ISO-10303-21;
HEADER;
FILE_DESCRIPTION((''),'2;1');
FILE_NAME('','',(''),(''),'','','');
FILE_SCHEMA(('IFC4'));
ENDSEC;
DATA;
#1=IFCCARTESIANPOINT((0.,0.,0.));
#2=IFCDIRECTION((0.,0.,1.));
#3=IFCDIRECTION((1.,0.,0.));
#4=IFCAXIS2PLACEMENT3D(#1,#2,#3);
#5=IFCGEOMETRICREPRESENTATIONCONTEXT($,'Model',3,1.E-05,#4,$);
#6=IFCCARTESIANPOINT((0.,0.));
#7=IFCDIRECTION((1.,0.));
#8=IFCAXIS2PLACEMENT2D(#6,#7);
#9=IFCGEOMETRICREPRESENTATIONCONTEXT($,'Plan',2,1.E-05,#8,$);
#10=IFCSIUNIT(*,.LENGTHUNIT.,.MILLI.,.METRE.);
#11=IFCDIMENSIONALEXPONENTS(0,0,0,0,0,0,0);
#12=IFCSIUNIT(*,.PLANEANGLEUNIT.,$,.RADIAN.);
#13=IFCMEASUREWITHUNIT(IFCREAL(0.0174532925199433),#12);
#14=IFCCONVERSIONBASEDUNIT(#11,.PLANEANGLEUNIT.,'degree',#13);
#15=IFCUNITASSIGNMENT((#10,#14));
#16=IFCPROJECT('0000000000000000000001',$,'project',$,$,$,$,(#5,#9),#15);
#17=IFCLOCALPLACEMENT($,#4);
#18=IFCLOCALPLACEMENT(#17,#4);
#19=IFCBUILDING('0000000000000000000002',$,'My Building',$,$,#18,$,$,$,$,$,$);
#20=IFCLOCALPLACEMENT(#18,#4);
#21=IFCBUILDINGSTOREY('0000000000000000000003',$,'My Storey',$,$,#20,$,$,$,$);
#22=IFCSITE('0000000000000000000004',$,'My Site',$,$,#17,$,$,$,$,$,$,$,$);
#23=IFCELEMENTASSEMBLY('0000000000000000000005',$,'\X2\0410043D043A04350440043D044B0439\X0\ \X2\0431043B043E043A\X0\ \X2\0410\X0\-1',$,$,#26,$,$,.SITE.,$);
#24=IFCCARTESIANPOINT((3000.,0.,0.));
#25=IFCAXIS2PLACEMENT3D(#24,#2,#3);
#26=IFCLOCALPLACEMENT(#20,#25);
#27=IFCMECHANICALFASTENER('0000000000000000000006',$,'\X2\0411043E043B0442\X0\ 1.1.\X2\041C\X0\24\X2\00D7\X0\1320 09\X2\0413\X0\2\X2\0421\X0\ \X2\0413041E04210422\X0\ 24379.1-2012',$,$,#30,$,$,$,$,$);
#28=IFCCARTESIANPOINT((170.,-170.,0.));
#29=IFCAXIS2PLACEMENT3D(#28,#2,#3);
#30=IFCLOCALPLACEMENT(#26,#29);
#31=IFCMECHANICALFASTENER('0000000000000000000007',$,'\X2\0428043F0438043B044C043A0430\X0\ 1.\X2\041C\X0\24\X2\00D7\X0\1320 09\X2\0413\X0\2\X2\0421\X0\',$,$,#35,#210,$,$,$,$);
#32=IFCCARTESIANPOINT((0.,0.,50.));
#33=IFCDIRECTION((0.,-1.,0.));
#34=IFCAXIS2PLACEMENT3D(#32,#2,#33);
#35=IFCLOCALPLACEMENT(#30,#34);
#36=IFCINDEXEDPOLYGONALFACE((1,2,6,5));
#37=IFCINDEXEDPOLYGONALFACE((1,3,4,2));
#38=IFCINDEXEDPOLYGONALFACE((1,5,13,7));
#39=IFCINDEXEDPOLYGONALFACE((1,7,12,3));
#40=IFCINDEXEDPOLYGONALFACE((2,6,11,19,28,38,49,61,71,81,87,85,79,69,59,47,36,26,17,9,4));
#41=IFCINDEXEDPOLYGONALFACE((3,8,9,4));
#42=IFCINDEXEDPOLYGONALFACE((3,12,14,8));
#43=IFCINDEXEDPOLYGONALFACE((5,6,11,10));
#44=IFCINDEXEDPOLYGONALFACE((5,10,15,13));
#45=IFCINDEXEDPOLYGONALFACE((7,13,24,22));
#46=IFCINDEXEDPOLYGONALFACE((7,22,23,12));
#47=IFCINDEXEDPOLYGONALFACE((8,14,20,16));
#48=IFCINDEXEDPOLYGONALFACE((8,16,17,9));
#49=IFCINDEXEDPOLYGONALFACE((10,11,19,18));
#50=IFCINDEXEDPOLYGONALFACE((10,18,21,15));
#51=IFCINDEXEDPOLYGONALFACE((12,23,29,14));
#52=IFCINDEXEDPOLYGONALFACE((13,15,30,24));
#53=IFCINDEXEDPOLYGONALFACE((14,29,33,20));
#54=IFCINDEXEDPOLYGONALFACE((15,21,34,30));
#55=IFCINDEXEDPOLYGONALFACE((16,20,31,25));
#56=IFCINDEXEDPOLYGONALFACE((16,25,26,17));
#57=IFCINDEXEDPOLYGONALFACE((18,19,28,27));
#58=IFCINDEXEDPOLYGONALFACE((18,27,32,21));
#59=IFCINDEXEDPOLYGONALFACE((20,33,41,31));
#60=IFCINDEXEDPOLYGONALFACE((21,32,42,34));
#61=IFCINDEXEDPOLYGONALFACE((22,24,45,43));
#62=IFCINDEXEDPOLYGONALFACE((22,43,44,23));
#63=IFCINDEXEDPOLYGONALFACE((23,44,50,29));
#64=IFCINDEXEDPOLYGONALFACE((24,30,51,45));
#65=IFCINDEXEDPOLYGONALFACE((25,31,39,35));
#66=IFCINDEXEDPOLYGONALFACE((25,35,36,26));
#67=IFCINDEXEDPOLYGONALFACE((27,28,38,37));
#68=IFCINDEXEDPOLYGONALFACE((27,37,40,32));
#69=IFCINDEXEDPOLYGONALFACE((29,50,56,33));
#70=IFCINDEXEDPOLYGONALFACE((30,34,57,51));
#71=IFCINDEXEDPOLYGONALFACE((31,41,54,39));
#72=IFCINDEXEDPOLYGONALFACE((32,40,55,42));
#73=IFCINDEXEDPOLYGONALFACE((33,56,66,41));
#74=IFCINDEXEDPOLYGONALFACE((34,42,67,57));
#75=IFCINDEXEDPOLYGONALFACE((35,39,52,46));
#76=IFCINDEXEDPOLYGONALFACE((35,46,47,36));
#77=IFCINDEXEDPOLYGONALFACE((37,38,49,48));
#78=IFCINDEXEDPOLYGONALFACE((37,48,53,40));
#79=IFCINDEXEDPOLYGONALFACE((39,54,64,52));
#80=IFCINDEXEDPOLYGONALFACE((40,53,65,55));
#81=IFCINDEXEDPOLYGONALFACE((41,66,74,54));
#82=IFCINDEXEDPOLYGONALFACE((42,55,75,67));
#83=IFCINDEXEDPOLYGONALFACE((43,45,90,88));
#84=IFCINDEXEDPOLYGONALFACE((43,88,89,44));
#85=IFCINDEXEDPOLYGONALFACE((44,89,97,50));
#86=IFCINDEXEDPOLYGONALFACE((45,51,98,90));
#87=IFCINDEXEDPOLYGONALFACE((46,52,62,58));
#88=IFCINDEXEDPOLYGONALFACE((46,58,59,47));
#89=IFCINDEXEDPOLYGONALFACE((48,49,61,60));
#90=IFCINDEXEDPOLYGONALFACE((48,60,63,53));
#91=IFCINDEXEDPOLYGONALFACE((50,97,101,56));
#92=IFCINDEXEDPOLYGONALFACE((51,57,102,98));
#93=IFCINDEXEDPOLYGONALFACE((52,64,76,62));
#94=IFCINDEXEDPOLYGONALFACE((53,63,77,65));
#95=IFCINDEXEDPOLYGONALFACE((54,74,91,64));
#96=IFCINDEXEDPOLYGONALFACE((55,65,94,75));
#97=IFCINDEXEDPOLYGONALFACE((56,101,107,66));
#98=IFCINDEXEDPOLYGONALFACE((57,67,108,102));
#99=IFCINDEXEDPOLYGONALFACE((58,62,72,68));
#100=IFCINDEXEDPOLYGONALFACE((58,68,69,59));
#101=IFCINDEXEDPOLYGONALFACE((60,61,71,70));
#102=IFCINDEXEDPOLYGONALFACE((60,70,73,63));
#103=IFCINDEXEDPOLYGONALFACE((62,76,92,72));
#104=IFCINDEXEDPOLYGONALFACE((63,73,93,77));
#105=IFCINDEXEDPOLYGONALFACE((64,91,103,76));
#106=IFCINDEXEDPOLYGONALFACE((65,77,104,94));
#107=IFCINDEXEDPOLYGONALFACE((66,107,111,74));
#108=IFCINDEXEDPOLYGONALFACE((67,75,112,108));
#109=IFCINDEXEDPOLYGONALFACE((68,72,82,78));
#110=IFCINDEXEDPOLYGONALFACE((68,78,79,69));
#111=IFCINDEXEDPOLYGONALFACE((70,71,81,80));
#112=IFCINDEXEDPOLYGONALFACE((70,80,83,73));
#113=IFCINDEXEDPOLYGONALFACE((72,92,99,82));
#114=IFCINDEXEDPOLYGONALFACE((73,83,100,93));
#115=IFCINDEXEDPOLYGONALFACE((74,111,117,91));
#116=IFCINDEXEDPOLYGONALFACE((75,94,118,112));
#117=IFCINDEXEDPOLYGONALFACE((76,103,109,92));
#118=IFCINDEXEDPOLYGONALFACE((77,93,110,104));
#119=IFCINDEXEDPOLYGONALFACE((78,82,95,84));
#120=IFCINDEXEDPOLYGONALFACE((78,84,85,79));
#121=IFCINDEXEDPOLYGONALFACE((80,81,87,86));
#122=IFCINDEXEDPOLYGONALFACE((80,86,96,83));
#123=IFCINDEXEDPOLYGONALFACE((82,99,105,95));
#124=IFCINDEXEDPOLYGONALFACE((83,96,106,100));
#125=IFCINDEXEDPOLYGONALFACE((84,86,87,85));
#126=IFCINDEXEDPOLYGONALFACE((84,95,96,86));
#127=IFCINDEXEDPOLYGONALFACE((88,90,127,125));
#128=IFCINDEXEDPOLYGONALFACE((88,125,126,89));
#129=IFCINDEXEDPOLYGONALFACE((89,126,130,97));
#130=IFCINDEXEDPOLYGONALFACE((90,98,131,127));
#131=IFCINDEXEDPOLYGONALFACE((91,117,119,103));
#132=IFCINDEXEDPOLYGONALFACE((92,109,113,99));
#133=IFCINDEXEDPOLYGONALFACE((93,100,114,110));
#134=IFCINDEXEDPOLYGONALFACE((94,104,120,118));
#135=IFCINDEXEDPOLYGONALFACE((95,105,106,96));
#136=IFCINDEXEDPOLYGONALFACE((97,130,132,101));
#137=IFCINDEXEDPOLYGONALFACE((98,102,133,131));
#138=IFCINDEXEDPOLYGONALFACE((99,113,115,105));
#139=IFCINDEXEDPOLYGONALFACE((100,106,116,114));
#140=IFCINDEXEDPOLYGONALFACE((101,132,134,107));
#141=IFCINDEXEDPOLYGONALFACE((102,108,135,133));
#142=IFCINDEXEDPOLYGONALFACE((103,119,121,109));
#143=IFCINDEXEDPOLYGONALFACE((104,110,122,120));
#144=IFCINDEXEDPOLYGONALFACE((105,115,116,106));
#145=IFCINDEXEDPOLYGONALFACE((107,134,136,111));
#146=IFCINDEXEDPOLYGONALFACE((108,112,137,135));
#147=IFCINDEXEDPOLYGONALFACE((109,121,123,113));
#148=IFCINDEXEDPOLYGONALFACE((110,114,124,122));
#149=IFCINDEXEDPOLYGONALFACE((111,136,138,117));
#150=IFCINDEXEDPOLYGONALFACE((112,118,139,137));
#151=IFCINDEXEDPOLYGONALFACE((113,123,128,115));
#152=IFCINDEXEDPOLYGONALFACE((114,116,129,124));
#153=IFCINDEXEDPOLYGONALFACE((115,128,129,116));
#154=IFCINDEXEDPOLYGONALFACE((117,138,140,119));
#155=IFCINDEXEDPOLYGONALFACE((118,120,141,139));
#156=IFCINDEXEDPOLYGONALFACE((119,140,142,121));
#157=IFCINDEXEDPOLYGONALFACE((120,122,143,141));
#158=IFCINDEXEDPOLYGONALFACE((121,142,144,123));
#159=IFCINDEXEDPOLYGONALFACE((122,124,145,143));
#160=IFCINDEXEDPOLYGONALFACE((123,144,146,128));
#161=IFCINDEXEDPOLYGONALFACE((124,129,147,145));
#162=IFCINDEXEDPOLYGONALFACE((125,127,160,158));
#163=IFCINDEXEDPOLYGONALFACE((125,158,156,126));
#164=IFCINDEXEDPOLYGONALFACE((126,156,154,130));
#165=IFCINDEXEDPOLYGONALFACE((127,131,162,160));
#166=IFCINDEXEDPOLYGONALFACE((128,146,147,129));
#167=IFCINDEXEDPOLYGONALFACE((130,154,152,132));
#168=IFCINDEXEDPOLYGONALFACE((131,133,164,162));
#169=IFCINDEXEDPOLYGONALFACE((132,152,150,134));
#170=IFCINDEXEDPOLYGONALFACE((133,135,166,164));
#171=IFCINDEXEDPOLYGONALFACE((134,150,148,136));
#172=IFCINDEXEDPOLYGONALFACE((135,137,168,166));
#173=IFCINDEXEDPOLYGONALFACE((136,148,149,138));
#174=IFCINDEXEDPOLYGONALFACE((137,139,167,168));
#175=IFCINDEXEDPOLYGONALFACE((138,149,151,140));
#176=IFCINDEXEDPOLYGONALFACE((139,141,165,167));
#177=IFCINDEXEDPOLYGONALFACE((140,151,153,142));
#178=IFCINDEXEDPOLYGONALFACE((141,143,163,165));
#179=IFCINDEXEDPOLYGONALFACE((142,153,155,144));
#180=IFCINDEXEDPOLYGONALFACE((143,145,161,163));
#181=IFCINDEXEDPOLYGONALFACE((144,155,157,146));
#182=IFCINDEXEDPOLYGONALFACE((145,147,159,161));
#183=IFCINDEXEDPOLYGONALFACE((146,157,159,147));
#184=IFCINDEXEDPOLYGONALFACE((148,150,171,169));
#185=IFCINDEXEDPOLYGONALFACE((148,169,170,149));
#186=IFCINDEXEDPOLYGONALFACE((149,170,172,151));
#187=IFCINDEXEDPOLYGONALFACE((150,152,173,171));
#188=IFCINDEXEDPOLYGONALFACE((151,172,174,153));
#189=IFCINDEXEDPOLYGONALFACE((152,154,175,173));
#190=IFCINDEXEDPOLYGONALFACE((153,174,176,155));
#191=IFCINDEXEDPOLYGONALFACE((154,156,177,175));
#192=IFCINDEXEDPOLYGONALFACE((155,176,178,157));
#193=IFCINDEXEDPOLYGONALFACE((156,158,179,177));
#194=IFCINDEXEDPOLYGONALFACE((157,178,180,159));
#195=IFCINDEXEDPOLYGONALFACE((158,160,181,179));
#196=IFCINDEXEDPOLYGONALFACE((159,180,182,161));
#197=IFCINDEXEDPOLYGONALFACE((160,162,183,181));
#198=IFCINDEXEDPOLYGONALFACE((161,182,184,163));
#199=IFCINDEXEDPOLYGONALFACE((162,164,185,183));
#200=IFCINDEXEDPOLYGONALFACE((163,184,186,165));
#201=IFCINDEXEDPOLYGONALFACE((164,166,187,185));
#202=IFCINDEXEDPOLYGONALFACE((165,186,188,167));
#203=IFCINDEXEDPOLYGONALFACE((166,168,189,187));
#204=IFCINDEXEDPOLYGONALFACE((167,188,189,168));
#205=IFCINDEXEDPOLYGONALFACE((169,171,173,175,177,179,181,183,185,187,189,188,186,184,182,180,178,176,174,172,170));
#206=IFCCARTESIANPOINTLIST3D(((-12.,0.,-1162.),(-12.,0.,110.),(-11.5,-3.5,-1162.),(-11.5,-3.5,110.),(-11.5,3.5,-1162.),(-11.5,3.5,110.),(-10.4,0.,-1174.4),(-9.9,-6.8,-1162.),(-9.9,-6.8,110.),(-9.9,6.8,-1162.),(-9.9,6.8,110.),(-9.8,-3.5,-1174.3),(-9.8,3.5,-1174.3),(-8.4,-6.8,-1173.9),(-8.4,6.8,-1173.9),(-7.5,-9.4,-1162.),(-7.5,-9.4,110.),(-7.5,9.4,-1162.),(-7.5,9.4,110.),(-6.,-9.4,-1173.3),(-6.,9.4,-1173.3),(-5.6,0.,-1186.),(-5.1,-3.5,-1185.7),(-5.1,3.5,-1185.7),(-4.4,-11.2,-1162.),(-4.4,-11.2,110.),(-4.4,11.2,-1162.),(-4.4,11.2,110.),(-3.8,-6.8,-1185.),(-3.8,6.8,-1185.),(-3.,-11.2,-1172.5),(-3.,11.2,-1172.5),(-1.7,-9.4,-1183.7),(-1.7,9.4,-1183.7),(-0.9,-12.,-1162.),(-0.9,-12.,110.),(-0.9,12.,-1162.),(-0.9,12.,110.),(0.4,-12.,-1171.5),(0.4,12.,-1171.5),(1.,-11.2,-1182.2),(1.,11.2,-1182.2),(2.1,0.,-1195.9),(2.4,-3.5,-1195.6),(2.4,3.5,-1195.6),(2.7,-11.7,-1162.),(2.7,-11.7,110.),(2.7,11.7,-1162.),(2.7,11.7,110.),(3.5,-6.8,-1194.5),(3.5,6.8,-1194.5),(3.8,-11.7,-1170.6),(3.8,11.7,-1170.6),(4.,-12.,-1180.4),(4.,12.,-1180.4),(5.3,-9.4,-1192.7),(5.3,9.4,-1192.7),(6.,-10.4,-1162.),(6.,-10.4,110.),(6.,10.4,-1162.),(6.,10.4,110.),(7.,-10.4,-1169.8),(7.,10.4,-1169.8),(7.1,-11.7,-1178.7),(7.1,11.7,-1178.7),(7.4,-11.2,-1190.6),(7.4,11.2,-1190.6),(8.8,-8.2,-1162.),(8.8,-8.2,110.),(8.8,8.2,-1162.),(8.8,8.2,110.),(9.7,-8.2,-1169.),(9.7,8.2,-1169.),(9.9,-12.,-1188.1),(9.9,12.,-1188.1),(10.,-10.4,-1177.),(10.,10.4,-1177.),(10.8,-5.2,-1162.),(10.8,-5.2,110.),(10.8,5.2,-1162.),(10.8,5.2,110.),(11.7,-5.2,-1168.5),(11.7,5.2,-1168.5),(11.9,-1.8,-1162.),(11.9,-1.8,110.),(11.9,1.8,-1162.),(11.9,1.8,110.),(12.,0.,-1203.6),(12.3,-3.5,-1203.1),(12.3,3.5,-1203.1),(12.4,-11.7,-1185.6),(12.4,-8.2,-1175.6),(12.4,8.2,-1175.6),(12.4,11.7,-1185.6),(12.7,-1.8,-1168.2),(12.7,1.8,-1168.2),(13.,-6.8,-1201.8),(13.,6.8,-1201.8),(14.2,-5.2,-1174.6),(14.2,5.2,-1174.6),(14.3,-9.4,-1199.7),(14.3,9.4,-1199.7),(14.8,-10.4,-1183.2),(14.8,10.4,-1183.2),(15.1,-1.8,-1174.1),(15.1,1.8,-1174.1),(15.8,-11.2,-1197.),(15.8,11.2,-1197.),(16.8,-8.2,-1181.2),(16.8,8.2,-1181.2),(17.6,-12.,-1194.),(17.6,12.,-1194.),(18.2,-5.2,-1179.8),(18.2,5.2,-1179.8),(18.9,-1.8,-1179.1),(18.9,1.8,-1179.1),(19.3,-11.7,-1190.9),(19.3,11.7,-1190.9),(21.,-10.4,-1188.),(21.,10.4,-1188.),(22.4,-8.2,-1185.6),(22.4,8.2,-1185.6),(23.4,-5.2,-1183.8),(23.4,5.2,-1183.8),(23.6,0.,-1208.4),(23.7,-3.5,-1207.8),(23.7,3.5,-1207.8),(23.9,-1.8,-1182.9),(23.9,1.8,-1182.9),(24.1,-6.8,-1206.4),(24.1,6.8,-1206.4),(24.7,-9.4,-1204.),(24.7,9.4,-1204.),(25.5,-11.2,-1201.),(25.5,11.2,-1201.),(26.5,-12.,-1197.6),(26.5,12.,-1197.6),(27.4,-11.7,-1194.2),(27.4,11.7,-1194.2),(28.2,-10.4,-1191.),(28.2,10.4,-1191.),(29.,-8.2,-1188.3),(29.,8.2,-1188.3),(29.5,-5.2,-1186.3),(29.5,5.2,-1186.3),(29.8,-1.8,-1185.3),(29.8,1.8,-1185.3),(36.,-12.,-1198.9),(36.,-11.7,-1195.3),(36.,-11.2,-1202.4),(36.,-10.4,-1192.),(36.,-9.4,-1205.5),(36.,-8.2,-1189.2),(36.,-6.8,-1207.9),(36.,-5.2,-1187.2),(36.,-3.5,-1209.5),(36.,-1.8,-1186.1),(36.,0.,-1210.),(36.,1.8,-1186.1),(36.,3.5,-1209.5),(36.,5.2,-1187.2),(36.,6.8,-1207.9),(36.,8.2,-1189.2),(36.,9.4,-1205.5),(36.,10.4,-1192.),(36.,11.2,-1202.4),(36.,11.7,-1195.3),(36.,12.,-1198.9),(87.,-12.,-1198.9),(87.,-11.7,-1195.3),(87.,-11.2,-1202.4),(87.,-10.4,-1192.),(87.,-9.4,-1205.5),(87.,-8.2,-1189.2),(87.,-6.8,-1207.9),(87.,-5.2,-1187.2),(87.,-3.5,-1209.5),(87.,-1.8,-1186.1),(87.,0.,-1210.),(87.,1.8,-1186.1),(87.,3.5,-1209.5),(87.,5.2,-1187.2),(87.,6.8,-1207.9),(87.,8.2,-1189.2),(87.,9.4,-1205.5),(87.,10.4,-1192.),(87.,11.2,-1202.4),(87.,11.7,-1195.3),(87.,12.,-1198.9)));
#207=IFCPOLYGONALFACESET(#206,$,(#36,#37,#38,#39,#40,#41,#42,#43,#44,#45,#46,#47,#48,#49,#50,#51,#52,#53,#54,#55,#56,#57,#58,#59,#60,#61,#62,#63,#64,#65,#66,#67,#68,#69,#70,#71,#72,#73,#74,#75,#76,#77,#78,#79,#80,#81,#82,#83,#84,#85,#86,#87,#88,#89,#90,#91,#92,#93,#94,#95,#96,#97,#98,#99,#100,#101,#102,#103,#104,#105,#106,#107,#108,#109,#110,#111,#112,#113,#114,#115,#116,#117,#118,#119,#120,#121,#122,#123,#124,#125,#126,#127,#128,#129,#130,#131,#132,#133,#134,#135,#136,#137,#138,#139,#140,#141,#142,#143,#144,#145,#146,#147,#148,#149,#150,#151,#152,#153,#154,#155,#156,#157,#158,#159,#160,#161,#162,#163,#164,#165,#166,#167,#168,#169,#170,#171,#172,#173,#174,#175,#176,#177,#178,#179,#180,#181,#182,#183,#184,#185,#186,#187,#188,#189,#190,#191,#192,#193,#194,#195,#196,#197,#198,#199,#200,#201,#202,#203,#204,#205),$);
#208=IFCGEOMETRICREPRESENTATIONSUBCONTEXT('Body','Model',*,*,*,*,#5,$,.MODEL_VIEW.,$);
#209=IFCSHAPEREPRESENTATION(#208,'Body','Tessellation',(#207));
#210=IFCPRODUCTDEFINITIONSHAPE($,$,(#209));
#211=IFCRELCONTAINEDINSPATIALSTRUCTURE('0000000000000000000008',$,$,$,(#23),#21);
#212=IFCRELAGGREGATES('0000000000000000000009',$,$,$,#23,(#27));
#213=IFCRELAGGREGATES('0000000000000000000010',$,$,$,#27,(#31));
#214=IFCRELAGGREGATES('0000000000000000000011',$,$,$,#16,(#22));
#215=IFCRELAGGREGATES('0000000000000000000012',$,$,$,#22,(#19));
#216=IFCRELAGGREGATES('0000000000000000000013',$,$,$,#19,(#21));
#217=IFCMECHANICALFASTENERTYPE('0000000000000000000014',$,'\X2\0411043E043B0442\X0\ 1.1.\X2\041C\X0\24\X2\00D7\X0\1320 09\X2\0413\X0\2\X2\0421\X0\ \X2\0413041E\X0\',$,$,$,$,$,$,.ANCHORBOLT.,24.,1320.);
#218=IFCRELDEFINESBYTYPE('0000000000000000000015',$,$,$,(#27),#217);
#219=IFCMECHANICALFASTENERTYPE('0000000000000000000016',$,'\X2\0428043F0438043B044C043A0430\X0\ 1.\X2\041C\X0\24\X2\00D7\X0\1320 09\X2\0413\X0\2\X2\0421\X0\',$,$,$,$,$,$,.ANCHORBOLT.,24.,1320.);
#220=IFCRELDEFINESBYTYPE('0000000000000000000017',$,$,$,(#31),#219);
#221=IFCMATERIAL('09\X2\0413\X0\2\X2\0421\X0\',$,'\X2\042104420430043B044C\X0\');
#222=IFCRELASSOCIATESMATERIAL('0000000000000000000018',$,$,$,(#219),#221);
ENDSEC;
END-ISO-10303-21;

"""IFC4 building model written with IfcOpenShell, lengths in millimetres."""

from ifc_helpers import new_model, entity, si_unit, converted_unit, frame, origin_with_axes, origin_2d_with_axis, place, context, subcontext, project, spatial, source, transform, mapped, material, type_object, type_shapes, element, aggregate, save


model = new_model("IFC4")

# Units and contexts
model_context = context("Model", 3, precision=1e-05, world=origin_with_axes())
plan_context = context("Plan", 2, precision=1e-05, world=origin_2d_with_axis())
body_context = subcontext(model_context, "Body", "Model", "MODEL_VIEW")
ifc_project = project(units=[si_unit("LENGTHUNIT", "METRE", prefix="MILLI"), converted_unit("PLANEANGLEUNIT", "degree", entity("IfcReal", 0.0174532925199433), si_unit("PLANEANGLEUNIT", "RADIAN"), dimensions=[0, 0, 0, 0, 0, 0, 0])], contexts=[model_context, plan_context])

# Site, building, storey
site_placement = place(None, origin_with_axes())
site = spatial("IfcSite", under=ifc_project, at=site_placement, Name="My Site")
building_placement = place(site_placement, origin_with_axes())
building = spatial("IfcBuilding", under=site, at=building_placement, Name="My Building")
storey_placement = place(building_placement, origin_with_axes())
storey = spatial("IfcBuildingStorey", under=building, at=storey_placement, Name="My Storey")

# Element assembly, mechanical fasteners
assembly_placement = place(storey_placement, frame((3000.0, 0.0, 0.0), z_axis=(0.0, 0.0, 1.0), x_axis=(1.0, 0.0, 0.0)))
assembly = element("IfcElementAssembly", 1, at=assembly_placement, inside=storey, Name="Анкерный блок А-1", AssemblyPlace="SITE")
mechanical_fastener_type_1 = type_object("IfcMechanicalFastenerType", Name="Болт 1.1.М24×1320 09Г2С ГО", NominalDiameter=24.0, NominalLength=1320.0, PredefinedType="ANCHORBOLT")
ifc_material_1 = material(Name="09Г2С", Category="Сталь")
mechanical_fastener_type_2 = type_object("IfcMechanicalFastenerType", Name="Шпилька 1.М24×1320 09Г2С", NominalDiameter=24.0, NominalLength=1320.0, PredefinedType="ANCHORBOLT", material=ifc_material_1)
shared_shape_1 = source(frame((0.0, 0.0, 110.0), z_axis=(0.0, 0.0, 1.0), x_axis=(1.0, 0.0, 0.0)), body_context, "Body", "AdvancedSweptSolid", [
    entity("IfcSweptDiskSolid", entity("IfcIndexedPolyCurve", entity("IfcCartesianPointList3D", [[0.0, 0.0, 0.0], [0.0, 0.0, -1272.0], [10.5, 0.0, -1297.5], [36.0, 0.0, -1308.0], [87.0, 0.0, -1308.0]]), [entity("IfcLineIndex", [1, 2]), entity("IfcArcIndex", [2, 3, 4]), entity("IfcLineIndex", [4, 5])]), 12.0),
])
type_shapes(mechanical_fastener_type_2, [shared_shape_1])
mechanical_fastener_1_placement = place(assembly_placement, frame((170.0, -170.0, 0.0), z_axis=(0.0, 0.0, 1.0), x_axis=(1.0, 0.0, 0.0)))
mechanical_fastener_1 = element("IfcMechanicalFastener", 2, at=mechanical_fastener_1_placement, type_object=mechanical_fastener_type_1, Name="Болт 1.1.М24×1320 09Г2С ГОСТ 24379.1-2012")
mechanical_fastener_2_placement = place(mechanical_fastener_1_placement, frame((0.0, 0.0, 50.0), z_axis=(0.0, 0.0, 1.0), x_axis=(0.0, -1.0, 0.0)))
mechanical_fastener_2 = element("IfcMechanicalFastener", 3, at=mechanical_fastener_2_placement, type_object=mechanical_fastener_type_2, Name="Шпилька 1.М24×1320 09Г2С", context=body_context, shape_type="MappedRepresentation", body=[
    mapped(shared_shape_1, transform((0.0, 0.0, 0.0), x_axis=(1.0, 0.0, 0.0), y_axis=(0.0, 1.0, 0.0), z_axis=(0.0, 0.0, 1.0), scale=1.0)),
])
aggregate(assembly, [mechanical_fastener_1])
aggregate(mechanical_fastener_1, [mechanical_fastener_2])

save(model, "model.ifc")
